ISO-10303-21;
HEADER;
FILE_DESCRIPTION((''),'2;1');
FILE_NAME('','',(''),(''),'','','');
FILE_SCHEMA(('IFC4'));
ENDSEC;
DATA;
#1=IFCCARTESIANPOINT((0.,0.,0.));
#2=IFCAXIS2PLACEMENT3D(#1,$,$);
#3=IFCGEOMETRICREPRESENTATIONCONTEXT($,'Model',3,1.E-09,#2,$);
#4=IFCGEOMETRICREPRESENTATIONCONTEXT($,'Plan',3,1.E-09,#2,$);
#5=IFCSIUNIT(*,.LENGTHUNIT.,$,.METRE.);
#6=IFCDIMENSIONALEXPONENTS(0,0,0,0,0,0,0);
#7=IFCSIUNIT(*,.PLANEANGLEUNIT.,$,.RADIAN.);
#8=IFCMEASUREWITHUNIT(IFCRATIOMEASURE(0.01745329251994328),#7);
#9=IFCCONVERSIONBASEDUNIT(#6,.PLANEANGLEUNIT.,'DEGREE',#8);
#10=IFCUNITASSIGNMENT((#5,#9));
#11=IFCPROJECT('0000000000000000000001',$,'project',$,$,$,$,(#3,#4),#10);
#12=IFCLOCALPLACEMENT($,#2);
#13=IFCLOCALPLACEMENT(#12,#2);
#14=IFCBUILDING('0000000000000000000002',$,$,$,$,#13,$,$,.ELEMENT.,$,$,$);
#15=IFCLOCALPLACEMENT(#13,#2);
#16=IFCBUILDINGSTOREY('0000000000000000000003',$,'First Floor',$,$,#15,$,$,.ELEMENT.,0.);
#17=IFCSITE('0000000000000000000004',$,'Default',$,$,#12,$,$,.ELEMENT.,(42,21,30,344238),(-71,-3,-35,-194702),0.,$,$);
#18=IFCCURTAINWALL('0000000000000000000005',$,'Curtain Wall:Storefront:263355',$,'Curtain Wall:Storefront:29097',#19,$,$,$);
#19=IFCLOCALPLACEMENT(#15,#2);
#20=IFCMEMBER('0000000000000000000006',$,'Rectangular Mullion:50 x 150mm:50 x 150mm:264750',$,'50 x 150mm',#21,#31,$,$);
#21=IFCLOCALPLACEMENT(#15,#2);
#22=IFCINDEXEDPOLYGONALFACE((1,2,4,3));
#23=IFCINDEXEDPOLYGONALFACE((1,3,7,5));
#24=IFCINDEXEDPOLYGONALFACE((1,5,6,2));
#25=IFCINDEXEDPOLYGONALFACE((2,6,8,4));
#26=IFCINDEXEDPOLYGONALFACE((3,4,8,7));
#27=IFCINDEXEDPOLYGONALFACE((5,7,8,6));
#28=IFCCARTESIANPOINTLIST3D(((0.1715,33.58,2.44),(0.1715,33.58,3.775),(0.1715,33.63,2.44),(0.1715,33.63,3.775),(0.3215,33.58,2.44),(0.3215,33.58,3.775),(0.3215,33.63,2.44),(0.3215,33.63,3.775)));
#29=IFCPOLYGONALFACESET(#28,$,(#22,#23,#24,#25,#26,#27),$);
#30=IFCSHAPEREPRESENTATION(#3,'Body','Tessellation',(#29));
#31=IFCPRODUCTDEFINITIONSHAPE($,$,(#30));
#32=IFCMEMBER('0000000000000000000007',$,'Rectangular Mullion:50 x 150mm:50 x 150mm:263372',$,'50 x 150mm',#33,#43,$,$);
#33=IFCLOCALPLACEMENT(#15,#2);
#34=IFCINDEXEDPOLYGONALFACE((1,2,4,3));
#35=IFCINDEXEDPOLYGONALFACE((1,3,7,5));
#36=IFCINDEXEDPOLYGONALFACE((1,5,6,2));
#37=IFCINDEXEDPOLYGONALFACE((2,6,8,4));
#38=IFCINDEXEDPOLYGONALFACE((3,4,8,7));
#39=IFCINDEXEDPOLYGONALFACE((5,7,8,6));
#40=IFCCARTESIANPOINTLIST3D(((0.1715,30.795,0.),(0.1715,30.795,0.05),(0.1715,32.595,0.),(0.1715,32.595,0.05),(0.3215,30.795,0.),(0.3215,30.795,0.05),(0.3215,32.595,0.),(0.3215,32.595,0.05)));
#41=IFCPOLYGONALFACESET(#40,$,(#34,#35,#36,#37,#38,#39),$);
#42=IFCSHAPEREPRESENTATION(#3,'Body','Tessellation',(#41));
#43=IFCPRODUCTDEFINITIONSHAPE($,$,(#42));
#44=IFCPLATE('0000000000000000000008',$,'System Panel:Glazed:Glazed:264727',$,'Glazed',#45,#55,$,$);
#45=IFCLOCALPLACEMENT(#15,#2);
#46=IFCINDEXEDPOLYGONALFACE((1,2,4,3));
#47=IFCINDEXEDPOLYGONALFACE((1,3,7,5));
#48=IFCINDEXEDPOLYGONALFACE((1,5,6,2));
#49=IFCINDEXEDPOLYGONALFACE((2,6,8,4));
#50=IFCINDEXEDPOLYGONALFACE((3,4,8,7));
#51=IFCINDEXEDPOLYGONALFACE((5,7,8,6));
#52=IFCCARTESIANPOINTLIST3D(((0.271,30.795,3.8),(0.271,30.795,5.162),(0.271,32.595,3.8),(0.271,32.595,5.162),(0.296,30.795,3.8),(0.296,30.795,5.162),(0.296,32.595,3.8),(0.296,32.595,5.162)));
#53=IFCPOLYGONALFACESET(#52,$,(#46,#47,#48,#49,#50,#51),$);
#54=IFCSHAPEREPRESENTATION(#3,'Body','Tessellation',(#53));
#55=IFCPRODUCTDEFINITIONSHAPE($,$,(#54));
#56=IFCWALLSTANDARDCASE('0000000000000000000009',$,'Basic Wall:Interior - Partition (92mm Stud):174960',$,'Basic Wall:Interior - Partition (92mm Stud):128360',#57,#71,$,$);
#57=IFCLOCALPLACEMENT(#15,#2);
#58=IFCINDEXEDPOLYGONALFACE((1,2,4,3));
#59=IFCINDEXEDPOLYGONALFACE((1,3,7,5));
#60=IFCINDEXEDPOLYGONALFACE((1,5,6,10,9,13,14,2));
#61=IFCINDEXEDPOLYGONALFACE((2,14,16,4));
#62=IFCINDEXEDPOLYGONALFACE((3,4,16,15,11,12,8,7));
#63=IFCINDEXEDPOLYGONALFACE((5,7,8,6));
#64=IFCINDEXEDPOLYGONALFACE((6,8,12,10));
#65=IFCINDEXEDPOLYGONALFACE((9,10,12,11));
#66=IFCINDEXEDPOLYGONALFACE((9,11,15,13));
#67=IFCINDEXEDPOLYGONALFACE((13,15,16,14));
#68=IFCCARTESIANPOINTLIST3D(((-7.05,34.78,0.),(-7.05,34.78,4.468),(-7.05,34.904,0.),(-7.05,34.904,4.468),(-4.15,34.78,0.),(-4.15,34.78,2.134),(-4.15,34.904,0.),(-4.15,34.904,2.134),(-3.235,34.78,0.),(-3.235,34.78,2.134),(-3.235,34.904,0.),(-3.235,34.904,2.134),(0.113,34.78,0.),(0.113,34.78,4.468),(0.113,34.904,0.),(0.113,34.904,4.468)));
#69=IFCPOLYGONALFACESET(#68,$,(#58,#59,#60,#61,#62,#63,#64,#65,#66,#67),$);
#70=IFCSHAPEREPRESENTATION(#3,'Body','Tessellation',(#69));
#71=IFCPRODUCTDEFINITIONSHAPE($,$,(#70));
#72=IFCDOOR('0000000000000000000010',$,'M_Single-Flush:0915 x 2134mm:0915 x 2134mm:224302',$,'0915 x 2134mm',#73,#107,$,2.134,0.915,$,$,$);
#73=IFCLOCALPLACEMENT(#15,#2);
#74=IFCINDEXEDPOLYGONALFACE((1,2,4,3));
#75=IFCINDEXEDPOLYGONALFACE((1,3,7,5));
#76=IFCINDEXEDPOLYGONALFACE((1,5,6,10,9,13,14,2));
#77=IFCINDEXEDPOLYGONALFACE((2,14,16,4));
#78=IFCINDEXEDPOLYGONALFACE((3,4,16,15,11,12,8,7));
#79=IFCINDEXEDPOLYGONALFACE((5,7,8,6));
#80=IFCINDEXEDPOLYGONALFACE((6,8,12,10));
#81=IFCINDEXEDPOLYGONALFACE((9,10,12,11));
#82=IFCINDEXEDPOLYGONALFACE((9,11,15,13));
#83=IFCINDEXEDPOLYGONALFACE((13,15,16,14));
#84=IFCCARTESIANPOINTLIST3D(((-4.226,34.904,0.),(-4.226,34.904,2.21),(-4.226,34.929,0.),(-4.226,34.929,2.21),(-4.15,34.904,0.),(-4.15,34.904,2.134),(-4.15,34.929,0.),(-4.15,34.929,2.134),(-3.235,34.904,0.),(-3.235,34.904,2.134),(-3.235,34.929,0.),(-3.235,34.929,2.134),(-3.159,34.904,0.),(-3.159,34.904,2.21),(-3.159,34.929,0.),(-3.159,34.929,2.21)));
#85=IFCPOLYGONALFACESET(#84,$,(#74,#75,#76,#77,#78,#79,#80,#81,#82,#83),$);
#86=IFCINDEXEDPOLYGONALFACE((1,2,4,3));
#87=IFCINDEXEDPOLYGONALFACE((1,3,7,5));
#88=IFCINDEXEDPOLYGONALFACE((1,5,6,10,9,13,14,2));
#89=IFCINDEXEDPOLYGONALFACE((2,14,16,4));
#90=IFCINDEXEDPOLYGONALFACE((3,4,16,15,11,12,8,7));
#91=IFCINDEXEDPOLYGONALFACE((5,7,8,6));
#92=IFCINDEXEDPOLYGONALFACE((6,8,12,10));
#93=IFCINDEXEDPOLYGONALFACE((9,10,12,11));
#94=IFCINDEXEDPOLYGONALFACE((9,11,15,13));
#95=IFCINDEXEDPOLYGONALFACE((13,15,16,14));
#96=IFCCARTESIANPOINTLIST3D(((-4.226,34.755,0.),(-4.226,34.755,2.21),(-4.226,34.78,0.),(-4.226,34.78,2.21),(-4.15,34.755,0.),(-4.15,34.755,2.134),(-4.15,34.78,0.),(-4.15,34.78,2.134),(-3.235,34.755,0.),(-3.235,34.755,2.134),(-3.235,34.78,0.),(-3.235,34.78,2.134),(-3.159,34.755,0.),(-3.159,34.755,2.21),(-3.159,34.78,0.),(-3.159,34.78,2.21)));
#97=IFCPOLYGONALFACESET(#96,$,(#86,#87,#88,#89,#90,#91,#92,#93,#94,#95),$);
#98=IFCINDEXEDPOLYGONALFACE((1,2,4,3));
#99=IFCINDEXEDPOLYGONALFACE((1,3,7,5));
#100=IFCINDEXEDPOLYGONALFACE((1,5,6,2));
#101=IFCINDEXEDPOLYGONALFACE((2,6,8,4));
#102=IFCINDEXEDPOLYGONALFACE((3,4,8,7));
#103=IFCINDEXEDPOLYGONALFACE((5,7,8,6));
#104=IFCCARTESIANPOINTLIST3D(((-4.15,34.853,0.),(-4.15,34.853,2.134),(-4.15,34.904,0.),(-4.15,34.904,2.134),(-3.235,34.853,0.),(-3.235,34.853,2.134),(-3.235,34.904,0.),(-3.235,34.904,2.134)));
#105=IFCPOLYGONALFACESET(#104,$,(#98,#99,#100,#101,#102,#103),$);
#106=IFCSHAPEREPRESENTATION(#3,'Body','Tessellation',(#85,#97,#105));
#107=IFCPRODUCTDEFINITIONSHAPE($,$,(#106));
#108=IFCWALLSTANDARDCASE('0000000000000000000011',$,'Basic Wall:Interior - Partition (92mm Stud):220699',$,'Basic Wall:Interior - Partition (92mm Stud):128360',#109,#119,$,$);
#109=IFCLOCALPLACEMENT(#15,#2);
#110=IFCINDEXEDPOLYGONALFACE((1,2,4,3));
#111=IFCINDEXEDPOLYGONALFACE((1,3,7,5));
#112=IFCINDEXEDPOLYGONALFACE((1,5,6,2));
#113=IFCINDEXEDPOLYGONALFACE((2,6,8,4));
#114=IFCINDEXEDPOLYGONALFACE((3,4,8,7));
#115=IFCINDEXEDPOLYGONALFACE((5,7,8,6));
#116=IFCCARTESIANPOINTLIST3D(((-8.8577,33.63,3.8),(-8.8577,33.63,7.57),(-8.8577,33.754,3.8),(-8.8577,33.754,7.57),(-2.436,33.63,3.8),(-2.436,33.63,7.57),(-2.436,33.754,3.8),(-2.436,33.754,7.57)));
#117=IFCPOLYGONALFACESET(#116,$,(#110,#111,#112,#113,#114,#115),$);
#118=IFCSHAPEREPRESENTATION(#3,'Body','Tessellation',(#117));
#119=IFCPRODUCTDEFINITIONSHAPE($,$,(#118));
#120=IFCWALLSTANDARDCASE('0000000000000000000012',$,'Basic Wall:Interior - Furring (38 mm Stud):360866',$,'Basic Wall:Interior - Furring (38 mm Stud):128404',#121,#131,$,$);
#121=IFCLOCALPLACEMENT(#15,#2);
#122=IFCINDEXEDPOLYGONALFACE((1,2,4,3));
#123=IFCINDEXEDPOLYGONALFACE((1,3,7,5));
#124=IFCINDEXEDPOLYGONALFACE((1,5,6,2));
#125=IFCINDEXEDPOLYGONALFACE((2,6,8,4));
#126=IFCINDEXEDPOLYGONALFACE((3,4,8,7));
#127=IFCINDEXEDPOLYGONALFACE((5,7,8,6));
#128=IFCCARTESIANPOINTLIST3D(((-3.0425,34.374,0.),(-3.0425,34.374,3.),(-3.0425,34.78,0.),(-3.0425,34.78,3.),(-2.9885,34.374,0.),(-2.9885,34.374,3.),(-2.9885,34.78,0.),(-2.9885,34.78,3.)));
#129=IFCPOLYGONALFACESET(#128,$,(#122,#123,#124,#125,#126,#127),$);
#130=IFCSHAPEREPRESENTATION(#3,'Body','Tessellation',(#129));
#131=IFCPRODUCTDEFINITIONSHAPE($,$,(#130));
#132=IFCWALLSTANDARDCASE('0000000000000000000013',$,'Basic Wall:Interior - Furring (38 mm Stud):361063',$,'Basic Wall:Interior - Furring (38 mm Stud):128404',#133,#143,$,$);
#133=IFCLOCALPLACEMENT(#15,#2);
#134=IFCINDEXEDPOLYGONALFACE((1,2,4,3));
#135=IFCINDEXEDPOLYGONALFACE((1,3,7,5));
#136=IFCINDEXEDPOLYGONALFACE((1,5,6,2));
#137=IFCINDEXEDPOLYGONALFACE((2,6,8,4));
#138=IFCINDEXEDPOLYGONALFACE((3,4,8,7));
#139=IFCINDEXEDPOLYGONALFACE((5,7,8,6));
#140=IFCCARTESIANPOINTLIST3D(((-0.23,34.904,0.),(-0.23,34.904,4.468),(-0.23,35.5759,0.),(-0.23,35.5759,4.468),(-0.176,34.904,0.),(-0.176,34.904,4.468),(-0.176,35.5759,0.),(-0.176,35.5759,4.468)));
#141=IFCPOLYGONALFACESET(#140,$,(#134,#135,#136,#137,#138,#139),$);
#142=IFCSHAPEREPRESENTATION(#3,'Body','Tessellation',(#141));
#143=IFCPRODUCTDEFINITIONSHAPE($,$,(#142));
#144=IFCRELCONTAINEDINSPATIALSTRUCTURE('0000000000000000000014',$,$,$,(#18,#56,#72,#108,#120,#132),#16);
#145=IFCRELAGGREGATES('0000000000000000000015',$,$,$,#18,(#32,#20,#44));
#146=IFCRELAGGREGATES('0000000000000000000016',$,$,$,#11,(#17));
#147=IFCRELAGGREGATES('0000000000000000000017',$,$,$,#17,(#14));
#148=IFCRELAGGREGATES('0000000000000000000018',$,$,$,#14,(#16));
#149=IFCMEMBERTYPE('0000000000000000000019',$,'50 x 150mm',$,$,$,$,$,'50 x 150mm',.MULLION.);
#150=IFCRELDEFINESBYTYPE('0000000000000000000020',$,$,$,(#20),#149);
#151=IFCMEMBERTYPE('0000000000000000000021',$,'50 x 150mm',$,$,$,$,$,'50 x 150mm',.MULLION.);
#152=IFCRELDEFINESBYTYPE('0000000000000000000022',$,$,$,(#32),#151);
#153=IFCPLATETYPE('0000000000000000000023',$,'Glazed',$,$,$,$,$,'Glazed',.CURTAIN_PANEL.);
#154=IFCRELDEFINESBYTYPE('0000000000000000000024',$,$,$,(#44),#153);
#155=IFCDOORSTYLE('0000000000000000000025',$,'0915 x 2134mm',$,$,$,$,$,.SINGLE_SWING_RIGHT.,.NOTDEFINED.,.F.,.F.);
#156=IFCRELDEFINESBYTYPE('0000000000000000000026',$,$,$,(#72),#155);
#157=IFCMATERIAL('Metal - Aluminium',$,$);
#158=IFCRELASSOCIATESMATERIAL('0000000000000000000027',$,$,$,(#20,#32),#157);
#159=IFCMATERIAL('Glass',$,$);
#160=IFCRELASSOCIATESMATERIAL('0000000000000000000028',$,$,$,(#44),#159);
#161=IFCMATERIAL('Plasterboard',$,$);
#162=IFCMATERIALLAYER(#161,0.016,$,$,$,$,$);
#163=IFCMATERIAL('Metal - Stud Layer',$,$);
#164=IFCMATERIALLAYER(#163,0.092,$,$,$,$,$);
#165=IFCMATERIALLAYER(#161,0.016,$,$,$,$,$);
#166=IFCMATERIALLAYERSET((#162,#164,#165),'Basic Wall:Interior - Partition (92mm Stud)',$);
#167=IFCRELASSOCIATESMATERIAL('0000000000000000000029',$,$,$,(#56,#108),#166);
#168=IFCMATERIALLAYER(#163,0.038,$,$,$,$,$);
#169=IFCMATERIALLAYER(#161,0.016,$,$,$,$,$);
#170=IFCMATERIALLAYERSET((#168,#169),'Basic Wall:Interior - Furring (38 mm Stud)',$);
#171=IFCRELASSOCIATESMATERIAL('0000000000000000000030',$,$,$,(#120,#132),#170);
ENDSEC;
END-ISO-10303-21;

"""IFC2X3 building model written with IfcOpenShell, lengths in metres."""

from ifc_helpers import new_model, entity, si_unit, converted_unit, frame, frame_2d, origin, origin_2d_with_axis, place, context, project, spatial, polyline, rectangle, outline, extrude, source, transform, mapped, material, layer, layer_set, layer_usage, type_object, type_shapes, element, fill, aggregate, save


model = new_model("IFC2X3")

# Units and contexts
model_context = context("Model", 3, precision=1e-09, world=origin())
plan_context = context("Plan", 3, precision=1e-09, world=origin())
ifc_project = project(units=[si_unit("LENGTHUNIT", "METRE"), converted_unit("PLANEANGLEUNIT", "DEGREE", entity("IfcRatioMeasure", 0.01745329251994328), si_unit("PLANEANGLEUNIT", "RADIAN"), dimensions=[0, 0, 0, 0, 0, 0, 0])], contexts=[model_context, plan_context])

# Site, building, storey
site_placement = place(None, origin())
site = spatial("IfcSite", under=ifc_project, at=site_placement, Name="Default", CompositionType="ELEMENT", RefLatitude=(42, 21, 30, 344238), RefLongitude=(-71, -3, -35, -194702), RefElevation=0.0)
building_placement = place(site_placement, origin())
building = spatial("IfcBuilding", under=site, at=building_placement, CompositionType="ELEMENT")
storey_placement = place(building_placement, origin())
storey = spatial("IfcBuildingStorey", under=building, at=storey_placement, Name="First Floor", CompositionType="ELEMENT", Elevation=0.0)

# Curtain wall, members, plate
curtain_wall_placement = place(storey_placement, origin())
curtain_wall = element("IfcCurtainWall", 1, at=curtain_wall_placement, inside=storey, Name="Curtain Wall:Storefront:263355", ObjectType="Curtain Wall:Storefront:29097")
ifc_material_1 = material(Name="Metal - Aluminium")
member_type_1 = type_object("IfcMemberType", Name="50 x 150mm", ElementType="50 x 150mm", PredefinedType="MULLION")
shared_shape_1 = source(origin(), model_context, "Body", "SweptSolid", [
    extrude(rectangle(XDim=0.05, YDim=0.15, at=origin_2d_with_axis()), frame((-0.025, 0.0, -1.335), z_axis=(0.0, 0.0, 1.0), x_axis=(-1.0, 0.0, 0.0)), (0.0, 0.0, 1.0), 1.335),
])
type_shapes(member_type_1, [shared_shape_1])
member_1_placement = place(storey_placement, frame((0.2465, 33.63, 3.775), z_axis=(0.0, 0.0, 1.0), x_axis=(0.0, 1.0, 0.0)))
member_1 = element("IfcMember", 2, at=member_1_placement, type_object=member_type_1, material=ifc_material_1, Name="Rectangular Mullion:50 x 150mm:50 x 150mm:264750", ObjectType="50 x 150mm", context=model_context, shape_type="MappedRepresentation", body=[
    mapped(shared_shape_1, transform((0.0, 0.0, 0.0), scale=1.0)),
])
member_type_2 = type_object("IfcMemberType", Name="50 x 150mm", ElementType="50 x 150mm", PredefinedType="MULLION")
shared_shape_2 = source(origin(), model_context, "Body", "SweptSolid", [
    extrude(rectangle(XDim=0.05, YDim=0.15, at=origin_2d_with_axis()), frame((-0.025, 0.0, -1.8), z_axis=(0.0, 0.0, 1.0), x_axis=(-1.0, 0.0, 0.0)), (0.0, 0.0, 1.0), 1.8),
])
type_shapes(member_type_2, [shared_shape_2])
member_2_placement = place(storey_placement, frame((0.2465, 32.595, 0.0), z_axis=(0.0, 1.0, 0.0), x_axis=(0.0, 0.0, -1.0)))
member_2 = element("IfcMember", 3, at=member_2_placement, type_object=member_type_2, material=ifc_material_1, Name="Rectangular Mullion:50 x 150mm:50 x 150mm:263372", ObjectType="50 x 150mm", context=model_context, shape_type="MappedRepresentation", body=[
    mapped(shared_shape_2, transform((0.0, 0.0, 0.0), scale=1.0)),
])
ifc_material_2 = material(Name="Glass")
plate_type_1 = type_object("IfcPlateType", Name="Glazed", ElementType="Glazed", PredefinedType="CURTAIN_PANEL")
shared_shape_3 = source(origin(), model_context, "Body", "SweptSolid", [
    extrude(rectangle(XDim=1.362, YDim=0.025, at=frame_2d((0.0, 0.0), x_axis=(0.0, 1.0))), frame((-0.9, 0.037, 0.681), z_axis=(1.0, 0.0, 0.0), x_axis=(0.0, 1.0, 0.0)), (0.0, 0.0, 1.0), 1.8),
])
type_shapes(plate_type_1, [shared_shape_3])
plate_1_placement = place(storey_placement, frame((0.2465, 31.695, 3.8), z_axis=(0.0, 0.0, 1.0), x_axis=(0.0, -1.0, 0.0)))
plate_1 = element("IfcPlate", 4, at=plate_1_placement, type_object=plate_type_1, material=ifc_material_2, Name="System Panel:Glazed:Glazed:264727", ObjectType="Glazed", context=model_context, shape_type="MappedRepresentation", body=[
    mapped(shared_shape_3, transform((0.0, 0.0, 0.0), scale=1.0)),
])
aggregate(curtain_wall, [member_2, member_1, plate_1])

# Wall, opening, door
ifc_material_3 = material(Name="Plasterboard")
ifc_layer_1 = layer(ifc_material_3, 0.016)
ifc_material_4 = material(Name="Metal - Stud Layer")
ifc_layer_2 = layer(ifc_material_4, 0.092)
ifc_layer_3 = layer(ifc_material_3, 0.016)
ifc_layer_set_1 = layer_set([ifc_layer_1, ifc_layer_2, ifc_layer_3], Name="Basic Wall:Interior - Partition (92mm Stud)")
ifc_layer_usage_1 = layer_usage(ifc_layer_set_1, "AXIS2", "NEGATIVE", 0.062)
wall_1_placement = place(storey_placement, frame((0.113, 34.842, 0.0), z_axis=(0.0, 0.0, 1.0), x_axis=(-1.0, 0.0, 0.0)))
wall_1 = element("IfcWallStandardCase", 5, at=wall_1_placement, inside=storey, material=ifc_layer_usage_1, Name="Basic Wall:Interior - Partition (92mm Stud):174960", ObjectType="Basic Wall:Interior - Partition (92mm Stud):128360", context=model_context, shape_type="SweptSolid", body=[
    extrude(rectangle(XDim=7.163, YDim=0.124, at=frame_2d((3.5815, 0.0), x_axis=(-1.0, 0.0))), origin(), (0.0, 0.0, 1.0), 4.468),
])
opening_placement = place(wall_1_placement, frame((4.263, 0.062, 0.0)))
opening = element("IfcOpeningElement", 6, at=opening_placement, cuts=wall_1, ObjectType="Opening", context=model_context, shape_type="SweptSolid", body=[
    extrude(rectangle(XDim=0.915, YDim=2.134, at=frame_2d((1.067, 0.4575), x_axis=(0.0, 1.0))), frame((0.0, 0.0, 0.0), z_axis=(0.0, -1.0, 0.0), x_axis=(0.0, 0.0, 1.0)), (0.0, 0.0, 1.0), 0.124),
])
door_style = type_object("IfcDoorStyle", Name="0915 x 2134mm", ConstructionType="NOTDEFINED", OperationType="SINGLE_SWING_RIGHT", ParameterTakesPrecedence=False, Sizeable=False)
shared_shape_4 = source(origin(), model_context, "Body", "SweptSolid", [
    extrude(outline(polyline([(-0.5335, -1.124), (0.5335, -1.124), (0.5335, 1.086), (0.4575, 1.086), (0.4575, -1.048), (-0.4575, -1.048), (-0.4575, 1.086), (-0.5335, 1.086), (-0.5335, -1.124)])), frame((0.4575, 0.124, 1.086), z_axis=(0.0, 1.0, 0.0), x_axis=(1.0, 0.0, 0.0)), (0.0, 0.0, 1.0), 0.025),
    extrude(outline(polyline([(-1.124, -0.5335), (1.086, -0.5335), (1.086, -0.4575), (-1.048, -0.4575), (-1.048, 0.4575), (1.086, 0.4575), (1.086, 0.5335), (-1.124, 0.5335), (-1.124, -0.5335)])), frame((0.4575, -0.025, 1.086), z_axis=(0.0, 1.0, 0.0), x_axis=(0.0, 0.0, -1.0)), (0.0, 0.0, 1.0), 0.025),
    extrude(rectangle(XDim=0.051, YDim=0.915, at=origin_2d_with_axis()), frame((0.4575, 0.0985, 0.0), z_axis=(0.0, 0.0, 1.0), x_axis=(0.0, 1.0, 0.0)), (0.0, 0.0, 1.0), 2.134),
])
type_shapes(door_style, [shared_shape_4])
door_placement = place(opening_placement, frame((0.0, 0.0, 0.0), z_axis=(0.0, 0.0, 1.0), x_axis=(-1.0, 0.0, 0.0)))
door = element("IfcDoor", 7, at=door_placement, inside=storey, type_object=door_style, Name="M_Single-Flush:0915 x 2134mm:0915 x 2134mm:224302", ObjectType="0915 x 2134mm", OverallHeight=2.134, OverallWidth=0.915, context=model_context, shape_type="MappedRepresentation", body=[
    mapped(shared_shape_4, transform((0.0, 0.0, 0.0), scale=1.0)),
])
fill(opening, door)

# Walls
wall_2_placement = place(storey_placement, frame((-2.436, 33.692, 3.8), z_axis=(0.0, 0.0, 1.0), x_axis=(-1.0, 0.0, 0.0)))
element("IfcWallStandardCase", 8, at=wall_2_placement, inside=storey, material=ifc_layer_usage_1, Name="Basic Wall:Interior - Partition (92mm Stud):220699", ObjectType="Basic Wall:Interior - Partition (92mm Stud):128360", context=model_context, shape_type="SweptSolid", body=[
    extrude(rectangle(XDim=6.4217, YDim=0.124, at=frame_2d((3.2109, 0.0), x_axis=(-1.0, 0.0))), origin(), (0.0, 0.0, 1.0), 3.77),
])
ifc_layer_4 = layer(ifc_material_4, 0.038)
ifc_layer_5 = layer(ifc_material_3, 0.016)
ifc_layer_set_2 = layer_set([ifc_layer_4, ifc_layer_5], Name="Basic Wall:Interior - Furring (38 mm Stud)")
ifc_layer_usage_2 = layer_usage(ifc_layer_set_2, "AXIS2", "NEGATIVE", 0.027)
wall_3_placement = place(storey_placement, frame((-3.0155, 34.374, 0.0), z_axis=(0.0, 0.0, 1.0), x_axis=(0.0, 1.0, 0.0)))
element("IfcWallStandardCase", 9, at=wall_3_placement, inside=storey, material=ifc_layer_usage_2, Name="Basic Wall:Interior - Furring (38 mm Stud):360866", ObjectType="Basic Wall:Interior - Furring (38 mm Stud):128404", context=model_context, shape_type="SweptSolid", body=[
    extrude(rectangle(XDim=0.406, YDim=0.054, at=frame_2d((0.203, 0.0), x_axis=(-1.0, 0.0))), origin(), (0.0, 0.0, 1.0), 3.0),
])
wall_4_placement = place(storey_placement, frame((-0.203, 35.5759, 0.0), z_axis=(0.0, 0.0, 1.0), x_axis=(0.0, -1.0, 0.0)))
element("IfcWallStandardCase", 10, at=wall_4_placement, inside=storey, material=ifc_layer_usage_2, Name="Basic Wall:Interior - Furring (38 mm Stud):361063", ObjectType="Basic Wall:Interior - Furring (38 mm Stud):128404", context=model_context, shape_type="SweptSolid", body=[
    extrude(rectangle(XDim=0.6719, YDim=0.054, at=frame_2d((0.336, 0.0), x_axis=(-1.0, 0.0))), origin(), (0.0, 0.0, 1.0), 4.468),
])

save(model, "model.ifc")
